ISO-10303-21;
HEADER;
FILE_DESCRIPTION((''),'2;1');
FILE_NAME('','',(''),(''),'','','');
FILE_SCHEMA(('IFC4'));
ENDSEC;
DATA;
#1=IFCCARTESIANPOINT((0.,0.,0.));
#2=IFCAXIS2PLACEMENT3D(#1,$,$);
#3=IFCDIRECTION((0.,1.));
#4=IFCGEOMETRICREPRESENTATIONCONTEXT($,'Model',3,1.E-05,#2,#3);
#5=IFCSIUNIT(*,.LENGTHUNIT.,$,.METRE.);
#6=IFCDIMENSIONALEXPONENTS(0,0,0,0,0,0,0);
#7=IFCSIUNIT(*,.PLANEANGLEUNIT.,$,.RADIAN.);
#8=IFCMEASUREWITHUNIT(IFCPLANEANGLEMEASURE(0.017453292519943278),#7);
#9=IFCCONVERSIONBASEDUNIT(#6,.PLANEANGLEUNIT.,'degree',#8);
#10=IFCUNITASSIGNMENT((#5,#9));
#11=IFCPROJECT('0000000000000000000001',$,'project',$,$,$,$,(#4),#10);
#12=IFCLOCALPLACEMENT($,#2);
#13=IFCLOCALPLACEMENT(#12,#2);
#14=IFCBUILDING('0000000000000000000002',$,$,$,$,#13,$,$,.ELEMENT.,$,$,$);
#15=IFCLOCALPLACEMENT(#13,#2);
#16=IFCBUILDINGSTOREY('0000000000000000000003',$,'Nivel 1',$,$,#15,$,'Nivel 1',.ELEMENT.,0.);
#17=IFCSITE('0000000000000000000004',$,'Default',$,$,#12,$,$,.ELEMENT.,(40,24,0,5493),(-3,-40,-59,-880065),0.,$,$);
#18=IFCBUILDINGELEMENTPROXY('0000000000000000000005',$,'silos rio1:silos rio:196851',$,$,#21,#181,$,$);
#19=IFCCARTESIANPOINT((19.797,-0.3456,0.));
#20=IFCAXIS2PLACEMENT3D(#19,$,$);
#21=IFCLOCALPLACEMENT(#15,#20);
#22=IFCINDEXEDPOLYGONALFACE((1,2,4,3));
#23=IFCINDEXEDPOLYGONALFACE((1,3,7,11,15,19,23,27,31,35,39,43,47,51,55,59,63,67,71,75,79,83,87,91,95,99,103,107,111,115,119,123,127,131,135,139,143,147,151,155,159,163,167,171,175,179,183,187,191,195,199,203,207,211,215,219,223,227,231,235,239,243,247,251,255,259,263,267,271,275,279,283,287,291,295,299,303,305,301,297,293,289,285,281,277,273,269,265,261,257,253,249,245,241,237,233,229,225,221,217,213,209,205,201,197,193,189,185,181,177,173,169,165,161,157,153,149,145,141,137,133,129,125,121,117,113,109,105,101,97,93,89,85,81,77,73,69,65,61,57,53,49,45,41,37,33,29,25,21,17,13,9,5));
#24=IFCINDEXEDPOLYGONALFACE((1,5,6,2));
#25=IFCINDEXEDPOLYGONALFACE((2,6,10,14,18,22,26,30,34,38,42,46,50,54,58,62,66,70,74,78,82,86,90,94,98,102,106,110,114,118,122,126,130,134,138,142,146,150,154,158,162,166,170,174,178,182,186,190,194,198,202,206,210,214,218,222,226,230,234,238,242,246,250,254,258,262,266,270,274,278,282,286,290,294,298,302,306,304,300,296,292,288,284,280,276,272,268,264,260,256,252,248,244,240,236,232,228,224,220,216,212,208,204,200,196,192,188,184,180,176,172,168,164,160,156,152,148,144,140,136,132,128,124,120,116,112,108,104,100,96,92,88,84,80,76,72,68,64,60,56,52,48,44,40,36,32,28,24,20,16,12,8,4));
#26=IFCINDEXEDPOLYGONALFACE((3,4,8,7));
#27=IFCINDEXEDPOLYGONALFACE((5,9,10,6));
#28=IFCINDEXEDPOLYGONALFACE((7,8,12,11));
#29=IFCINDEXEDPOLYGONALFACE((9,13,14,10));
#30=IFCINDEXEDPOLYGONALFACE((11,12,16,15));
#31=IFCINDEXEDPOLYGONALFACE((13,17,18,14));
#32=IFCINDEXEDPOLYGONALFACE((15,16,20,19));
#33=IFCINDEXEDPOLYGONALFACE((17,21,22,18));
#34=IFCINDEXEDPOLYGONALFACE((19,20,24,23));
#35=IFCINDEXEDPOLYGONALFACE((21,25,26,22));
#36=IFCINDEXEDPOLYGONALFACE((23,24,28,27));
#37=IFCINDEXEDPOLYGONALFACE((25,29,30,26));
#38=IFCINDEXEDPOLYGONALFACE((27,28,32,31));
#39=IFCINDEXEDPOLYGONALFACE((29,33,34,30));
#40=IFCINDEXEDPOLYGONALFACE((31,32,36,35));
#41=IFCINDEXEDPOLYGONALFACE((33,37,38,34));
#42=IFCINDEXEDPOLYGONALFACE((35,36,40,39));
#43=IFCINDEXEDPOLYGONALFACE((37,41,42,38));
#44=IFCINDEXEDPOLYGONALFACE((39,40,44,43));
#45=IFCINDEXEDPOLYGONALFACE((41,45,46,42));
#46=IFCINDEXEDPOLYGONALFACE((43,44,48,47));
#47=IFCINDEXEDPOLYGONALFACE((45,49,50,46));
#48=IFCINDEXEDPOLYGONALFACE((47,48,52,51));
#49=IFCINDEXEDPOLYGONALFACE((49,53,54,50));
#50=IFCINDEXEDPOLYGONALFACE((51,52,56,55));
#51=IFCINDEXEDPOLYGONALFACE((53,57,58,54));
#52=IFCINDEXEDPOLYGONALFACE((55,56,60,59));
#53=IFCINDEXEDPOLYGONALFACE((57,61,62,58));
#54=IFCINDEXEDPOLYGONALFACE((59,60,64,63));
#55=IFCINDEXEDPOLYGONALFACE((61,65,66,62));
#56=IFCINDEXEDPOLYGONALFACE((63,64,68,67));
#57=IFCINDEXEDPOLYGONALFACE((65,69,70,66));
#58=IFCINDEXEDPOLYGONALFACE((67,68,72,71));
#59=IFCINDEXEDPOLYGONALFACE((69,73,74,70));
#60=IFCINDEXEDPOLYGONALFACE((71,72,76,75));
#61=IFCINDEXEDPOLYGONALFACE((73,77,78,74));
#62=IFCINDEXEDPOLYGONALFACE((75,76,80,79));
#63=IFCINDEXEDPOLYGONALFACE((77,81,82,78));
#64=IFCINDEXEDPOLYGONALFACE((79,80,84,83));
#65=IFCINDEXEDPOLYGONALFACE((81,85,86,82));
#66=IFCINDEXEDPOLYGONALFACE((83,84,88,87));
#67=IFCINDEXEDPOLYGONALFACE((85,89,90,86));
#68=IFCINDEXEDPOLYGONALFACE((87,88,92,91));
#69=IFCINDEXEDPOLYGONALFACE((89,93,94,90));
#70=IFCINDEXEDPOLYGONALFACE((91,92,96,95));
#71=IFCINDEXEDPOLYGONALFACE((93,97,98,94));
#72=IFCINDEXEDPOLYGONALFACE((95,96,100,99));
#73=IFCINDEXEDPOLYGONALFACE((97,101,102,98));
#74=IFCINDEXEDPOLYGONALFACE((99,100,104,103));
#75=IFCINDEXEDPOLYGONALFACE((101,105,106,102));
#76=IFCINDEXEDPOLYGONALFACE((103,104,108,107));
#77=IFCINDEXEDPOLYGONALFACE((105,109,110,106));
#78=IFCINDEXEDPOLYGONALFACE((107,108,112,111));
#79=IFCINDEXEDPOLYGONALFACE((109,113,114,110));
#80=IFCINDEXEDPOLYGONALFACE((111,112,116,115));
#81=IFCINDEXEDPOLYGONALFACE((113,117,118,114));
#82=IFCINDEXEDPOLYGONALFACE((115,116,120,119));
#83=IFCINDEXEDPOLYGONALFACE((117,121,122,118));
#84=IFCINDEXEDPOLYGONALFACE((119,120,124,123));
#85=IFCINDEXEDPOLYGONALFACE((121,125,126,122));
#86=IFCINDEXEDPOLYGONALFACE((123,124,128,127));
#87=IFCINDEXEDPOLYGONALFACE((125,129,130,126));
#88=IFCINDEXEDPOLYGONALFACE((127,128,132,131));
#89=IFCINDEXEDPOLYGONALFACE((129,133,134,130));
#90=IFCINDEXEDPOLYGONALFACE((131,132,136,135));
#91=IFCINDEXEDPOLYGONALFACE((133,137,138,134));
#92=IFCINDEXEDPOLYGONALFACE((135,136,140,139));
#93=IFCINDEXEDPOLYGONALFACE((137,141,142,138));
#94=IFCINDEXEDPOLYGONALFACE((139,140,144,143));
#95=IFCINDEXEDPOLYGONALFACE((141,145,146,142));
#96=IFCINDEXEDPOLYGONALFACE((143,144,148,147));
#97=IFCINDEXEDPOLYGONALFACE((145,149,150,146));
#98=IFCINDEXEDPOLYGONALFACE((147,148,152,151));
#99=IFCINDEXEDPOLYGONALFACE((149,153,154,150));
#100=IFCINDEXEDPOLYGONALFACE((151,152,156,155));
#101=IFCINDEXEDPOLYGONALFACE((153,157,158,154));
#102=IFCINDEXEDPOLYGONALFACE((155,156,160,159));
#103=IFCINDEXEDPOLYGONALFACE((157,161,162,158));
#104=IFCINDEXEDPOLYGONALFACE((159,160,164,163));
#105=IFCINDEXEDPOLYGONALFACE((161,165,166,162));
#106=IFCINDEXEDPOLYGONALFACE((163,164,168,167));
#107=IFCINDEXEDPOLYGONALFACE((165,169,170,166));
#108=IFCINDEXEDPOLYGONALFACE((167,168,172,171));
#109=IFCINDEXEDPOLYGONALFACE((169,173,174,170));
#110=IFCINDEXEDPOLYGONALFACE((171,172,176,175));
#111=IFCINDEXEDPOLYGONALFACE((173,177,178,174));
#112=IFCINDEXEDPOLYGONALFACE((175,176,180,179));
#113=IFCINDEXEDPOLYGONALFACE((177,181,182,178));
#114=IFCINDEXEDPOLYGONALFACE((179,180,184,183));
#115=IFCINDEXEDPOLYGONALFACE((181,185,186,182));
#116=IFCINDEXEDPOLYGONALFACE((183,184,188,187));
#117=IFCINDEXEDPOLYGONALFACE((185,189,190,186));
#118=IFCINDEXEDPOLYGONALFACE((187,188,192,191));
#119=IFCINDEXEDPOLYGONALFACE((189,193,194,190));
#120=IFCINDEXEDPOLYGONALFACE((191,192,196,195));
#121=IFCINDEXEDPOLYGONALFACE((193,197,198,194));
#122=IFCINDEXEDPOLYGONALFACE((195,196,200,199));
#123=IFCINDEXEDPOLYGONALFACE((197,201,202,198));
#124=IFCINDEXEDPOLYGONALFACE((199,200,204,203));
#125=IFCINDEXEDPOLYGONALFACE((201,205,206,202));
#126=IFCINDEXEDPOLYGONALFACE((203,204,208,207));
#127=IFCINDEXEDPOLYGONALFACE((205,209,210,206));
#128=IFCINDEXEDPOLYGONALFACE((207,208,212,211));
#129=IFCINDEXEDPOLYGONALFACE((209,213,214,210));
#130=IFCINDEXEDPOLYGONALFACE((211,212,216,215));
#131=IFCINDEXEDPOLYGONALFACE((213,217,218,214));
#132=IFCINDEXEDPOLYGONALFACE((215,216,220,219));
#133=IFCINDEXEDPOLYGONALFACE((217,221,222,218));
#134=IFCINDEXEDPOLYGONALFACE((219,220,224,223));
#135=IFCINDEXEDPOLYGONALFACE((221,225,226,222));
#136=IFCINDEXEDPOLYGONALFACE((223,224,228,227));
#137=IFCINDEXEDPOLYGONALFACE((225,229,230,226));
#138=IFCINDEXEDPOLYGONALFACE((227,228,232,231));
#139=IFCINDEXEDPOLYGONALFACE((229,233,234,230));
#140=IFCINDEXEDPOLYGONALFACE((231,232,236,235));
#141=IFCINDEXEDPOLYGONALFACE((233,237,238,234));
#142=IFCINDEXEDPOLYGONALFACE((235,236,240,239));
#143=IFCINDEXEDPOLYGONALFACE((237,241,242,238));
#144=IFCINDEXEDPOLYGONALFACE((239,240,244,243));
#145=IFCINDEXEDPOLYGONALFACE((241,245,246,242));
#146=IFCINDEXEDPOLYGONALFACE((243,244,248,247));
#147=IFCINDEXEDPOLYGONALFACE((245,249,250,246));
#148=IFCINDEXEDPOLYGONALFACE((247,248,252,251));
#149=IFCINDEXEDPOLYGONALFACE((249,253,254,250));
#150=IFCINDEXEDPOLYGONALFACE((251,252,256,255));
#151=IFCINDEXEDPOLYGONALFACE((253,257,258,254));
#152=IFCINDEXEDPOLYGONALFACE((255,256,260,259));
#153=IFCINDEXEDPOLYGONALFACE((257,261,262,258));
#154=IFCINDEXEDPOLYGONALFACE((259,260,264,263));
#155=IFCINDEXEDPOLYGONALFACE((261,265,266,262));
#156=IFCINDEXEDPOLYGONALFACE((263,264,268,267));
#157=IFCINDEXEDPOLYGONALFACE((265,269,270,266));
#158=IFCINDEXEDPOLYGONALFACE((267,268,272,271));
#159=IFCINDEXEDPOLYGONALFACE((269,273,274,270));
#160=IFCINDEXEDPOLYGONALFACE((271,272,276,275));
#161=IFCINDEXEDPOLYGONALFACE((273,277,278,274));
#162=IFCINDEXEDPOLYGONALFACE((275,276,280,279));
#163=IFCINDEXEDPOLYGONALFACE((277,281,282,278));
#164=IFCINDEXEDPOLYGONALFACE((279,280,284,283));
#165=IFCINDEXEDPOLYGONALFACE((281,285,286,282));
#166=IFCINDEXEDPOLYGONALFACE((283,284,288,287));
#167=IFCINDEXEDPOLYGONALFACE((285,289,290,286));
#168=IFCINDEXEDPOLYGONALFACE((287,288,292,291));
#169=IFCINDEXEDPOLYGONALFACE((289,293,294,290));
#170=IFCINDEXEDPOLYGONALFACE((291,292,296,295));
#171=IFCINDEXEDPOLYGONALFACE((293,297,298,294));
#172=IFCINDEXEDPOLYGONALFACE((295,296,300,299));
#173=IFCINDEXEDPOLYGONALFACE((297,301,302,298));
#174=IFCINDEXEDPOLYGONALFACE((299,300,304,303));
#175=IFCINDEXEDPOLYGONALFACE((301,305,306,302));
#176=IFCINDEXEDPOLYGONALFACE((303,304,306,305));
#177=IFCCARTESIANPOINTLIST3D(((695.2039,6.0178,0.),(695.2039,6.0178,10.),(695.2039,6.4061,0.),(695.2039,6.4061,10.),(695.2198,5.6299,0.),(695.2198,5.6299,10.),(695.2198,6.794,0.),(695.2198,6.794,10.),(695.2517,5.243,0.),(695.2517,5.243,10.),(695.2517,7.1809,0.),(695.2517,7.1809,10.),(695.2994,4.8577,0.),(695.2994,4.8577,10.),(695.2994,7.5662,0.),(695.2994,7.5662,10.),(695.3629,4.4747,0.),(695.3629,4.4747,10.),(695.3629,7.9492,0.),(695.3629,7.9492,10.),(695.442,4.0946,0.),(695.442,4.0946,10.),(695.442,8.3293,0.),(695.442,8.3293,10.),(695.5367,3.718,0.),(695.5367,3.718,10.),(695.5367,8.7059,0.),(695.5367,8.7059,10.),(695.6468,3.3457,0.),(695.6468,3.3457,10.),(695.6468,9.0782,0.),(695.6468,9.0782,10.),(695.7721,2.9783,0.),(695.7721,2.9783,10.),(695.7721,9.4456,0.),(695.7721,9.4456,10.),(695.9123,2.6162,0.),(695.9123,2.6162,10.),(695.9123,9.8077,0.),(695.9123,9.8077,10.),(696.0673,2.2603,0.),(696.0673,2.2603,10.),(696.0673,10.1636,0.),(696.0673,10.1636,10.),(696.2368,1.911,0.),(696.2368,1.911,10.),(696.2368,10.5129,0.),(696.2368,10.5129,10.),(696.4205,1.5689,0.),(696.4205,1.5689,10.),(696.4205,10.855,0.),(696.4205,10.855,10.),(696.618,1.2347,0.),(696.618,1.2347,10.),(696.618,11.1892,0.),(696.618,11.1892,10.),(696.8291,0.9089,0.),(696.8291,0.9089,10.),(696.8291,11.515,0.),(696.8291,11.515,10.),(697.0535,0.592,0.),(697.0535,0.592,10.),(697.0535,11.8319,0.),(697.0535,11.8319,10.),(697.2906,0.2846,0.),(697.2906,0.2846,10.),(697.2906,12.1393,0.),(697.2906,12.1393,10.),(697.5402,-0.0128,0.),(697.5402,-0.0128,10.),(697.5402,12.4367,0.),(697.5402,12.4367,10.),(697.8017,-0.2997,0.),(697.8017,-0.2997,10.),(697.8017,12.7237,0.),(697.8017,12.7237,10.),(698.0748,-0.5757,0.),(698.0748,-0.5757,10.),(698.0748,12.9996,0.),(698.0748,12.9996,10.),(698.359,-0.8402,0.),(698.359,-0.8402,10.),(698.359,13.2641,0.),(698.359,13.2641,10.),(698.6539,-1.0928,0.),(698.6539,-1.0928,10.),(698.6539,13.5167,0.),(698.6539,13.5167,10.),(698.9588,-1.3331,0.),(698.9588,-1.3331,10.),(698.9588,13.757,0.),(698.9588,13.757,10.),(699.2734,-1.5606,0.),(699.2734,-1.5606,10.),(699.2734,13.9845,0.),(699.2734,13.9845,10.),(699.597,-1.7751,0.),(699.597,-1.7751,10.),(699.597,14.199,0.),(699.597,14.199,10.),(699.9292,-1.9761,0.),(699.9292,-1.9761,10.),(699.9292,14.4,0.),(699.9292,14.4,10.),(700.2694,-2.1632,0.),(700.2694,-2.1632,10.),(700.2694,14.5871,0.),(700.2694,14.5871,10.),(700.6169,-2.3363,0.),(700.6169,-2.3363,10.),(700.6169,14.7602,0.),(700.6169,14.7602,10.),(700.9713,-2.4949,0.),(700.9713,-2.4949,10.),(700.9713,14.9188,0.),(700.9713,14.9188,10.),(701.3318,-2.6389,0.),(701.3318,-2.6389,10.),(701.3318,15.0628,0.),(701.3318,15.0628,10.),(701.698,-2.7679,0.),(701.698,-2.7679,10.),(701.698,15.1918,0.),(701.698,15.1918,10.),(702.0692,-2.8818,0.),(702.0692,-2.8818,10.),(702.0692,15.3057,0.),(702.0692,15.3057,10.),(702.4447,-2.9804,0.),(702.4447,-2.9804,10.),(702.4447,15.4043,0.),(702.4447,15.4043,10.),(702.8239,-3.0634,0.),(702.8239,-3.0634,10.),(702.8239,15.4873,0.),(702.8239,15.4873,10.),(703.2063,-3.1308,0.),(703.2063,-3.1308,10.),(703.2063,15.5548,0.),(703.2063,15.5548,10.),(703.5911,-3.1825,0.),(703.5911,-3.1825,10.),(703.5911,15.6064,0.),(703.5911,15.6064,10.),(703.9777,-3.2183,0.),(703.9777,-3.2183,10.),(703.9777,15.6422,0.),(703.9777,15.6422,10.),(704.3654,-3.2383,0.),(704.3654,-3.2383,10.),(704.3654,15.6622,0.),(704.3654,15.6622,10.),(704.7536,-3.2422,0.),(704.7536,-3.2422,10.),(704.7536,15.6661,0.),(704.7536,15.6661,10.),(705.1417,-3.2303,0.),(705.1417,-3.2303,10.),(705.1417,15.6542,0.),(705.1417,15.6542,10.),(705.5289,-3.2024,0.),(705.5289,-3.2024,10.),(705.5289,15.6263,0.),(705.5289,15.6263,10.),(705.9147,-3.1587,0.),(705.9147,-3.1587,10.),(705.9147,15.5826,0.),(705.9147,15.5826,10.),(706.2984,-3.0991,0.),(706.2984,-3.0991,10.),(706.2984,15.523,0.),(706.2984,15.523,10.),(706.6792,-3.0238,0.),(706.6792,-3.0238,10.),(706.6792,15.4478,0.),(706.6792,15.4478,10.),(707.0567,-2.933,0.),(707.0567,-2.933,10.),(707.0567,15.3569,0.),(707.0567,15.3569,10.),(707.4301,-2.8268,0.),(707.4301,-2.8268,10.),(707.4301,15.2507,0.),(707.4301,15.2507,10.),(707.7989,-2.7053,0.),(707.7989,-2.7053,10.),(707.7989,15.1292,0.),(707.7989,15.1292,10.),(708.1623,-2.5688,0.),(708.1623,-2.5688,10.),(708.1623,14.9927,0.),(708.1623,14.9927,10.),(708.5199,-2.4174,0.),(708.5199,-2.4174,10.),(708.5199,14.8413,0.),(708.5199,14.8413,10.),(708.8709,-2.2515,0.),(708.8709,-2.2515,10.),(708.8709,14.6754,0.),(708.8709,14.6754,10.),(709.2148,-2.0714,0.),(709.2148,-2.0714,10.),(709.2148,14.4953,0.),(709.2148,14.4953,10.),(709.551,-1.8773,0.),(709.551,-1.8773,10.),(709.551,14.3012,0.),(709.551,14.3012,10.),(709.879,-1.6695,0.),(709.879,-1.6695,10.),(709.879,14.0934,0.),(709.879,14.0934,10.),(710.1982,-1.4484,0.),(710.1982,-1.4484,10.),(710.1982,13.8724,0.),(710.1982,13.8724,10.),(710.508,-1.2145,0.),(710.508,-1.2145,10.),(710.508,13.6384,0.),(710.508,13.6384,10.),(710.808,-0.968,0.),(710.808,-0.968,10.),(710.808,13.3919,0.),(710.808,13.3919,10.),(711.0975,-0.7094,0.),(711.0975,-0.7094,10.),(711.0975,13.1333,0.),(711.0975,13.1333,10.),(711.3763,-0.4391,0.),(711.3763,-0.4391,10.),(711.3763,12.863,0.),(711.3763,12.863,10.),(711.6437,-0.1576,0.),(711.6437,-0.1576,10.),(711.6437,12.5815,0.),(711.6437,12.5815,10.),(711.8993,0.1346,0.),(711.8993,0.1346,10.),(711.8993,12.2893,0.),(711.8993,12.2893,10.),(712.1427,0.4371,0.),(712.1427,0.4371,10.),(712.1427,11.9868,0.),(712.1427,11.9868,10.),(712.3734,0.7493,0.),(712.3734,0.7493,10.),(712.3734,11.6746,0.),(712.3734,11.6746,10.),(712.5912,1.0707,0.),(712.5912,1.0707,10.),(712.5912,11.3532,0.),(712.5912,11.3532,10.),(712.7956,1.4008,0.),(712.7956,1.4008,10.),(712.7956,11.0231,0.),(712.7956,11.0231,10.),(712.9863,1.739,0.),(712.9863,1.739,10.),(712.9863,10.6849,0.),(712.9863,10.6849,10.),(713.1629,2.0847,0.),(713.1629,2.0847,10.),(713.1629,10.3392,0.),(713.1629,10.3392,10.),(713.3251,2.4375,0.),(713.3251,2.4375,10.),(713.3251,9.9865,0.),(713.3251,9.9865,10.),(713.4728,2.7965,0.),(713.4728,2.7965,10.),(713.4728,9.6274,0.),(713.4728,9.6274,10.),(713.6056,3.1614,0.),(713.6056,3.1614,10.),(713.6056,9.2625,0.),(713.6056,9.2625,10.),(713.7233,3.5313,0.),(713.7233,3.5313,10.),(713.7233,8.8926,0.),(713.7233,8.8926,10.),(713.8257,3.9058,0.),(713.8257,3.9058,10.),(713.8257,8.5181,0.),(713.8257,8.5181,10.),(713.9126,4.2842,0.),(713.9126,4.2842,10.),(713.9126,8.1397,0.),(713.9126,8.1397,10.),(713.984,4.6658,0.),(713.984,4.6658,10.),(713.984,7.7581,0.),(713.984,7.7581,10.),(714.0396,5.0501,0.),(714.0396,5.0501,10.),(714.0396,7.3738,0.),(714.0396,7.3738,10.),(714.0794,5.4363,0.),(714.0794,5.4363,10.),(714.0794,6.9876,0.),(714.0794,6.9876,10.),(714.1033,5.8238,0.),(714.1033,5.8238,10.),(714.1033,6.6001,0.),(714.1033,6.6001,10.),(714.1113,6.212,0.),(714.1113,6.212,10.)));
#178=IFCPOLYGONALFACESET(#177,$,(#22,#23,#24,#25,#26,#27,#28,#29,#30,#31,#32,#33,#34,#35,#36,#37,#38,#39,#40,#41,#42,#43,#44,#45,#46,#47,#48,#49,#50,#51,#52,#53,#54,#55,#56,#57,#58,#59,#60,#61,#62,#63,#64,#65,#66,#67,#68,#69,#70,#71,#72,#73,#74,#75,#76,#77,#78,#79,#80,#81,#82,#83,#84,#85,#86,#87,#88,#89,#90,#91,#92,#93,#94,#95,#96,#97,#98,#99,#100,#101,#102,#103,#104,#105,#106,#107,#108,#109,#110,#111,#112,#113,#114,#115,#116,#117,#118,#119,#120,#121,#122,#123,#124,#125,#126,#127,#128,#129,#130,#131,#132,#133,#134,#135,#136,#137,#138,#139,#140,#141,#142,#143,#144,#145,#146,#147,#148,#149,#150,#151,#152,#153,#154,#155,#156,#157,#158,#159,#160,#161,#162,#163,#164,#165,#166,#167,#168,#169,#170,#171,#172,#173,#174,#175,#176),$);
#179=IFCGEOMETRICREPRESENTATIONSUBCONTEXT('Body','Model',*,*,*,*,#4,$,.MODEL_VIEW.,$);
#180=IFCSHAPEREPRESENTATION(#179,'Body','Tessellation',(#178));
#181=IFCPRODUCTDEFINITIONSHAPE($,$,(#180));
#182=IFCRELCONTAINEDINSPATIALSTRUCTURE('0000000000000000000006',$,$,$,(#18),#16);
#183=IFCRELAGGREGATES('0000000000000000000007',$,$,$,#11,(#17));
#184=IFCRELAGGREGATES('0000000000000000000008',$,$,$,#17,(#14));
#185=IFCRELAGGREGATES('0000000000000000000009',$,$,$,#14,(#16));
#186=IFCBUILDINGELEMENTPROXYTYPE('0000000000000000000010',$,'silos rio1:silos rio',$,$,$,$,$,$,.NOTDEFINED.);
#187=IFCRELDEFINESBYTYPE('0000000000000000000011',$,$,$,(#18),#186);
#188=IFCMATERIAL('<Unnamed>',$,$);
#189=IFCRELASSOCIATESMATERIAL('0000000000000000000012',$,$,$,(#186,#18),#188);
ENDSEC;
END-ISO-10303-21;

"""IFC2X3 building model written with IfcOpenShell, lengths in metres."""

from ifc_helpers import new_model, entity, si_unit, converted_unit, direction, frame, frame_2d, origin, place, context, subcontext, project, spatial, circle, extrude, source, transform, mapped, material, type_object, type_shapes, element, save


model = new_model("IFC2X3")

# Units and contexts
model_context = context("Model", 3, precision=1e-05, world=origin(), true_north=direction((0.0, 1.0)))
body_context = subcontext(model_context, "Body", "Model", "MODEL_VIEW")
ifc_project = project(units=[si_unit("LENGTHUNIT", "METRE"), converted_unit("PLANEANGLEUNIT", "degree", entity("IfcPlaneAngleMeasure", 0.017453292519943278), si_unit("PLANEANGLEUNIT", "RADIAN"), dimensions=[0, 0, 0, 0, 0, 0, 0])], contexts=[model_context])

# Site, building, storey
site_placement = place(None, origin())
site = spatial("IfcSite", under=ifc_project, at=site_placement, Name="Default", CompositionType="ELEMENT", RefLatitude=(40, 24, 0, 5493), RefLongitude=(-3, -40, -59, -880065), RefElevation=0.0)
building_placement = place(site_placement, origin())
building = spatial("IfcBuilding", under=site, at=building_placement, CompositionType="ELEMENT")
storey_placement = place(building_placement, origin())
storey = spatial("IfcBuildingStorey", under=building, at=storey_placement, Name="Nivel 1", LongName="Nivel 1", CompositionType="ELEMENT", Elevation=0.0)

# Building element proxy
ifc_material_1 = material(Name="<Unnamed>")
building_element_proxy_type_1 = type_object("IfcBuildingElementProxyType", Name="silos rio1:silos rio", PredefinedType="NOTDEFINED", material=ifc_material_1)
shared_shape_1 = source(origin(), body_context, "Body", "SweptSolid", [
    extrude(circle(Radius=9.4547, at=frame_2d((0.0, 0.0), x_axis=(1.0, 0.0))), frame((704.6566, 6.212, 0.0)), (0.0, 0.0, 1.0), 10.0),
])
type_shapes(building_element_proxy_type_1, [shared_shape_1])
proxy_1_placement = place(storey_placement, frame((19.797, -0.3456, 0.0)))
element("IfcBuildingElementProxy", 1, at=proxy_1_placement, inside=storey, type_object=building_element_proxy_type_1, material=ifc_material_1, Name="silos rio1:silos rio:196851", context=body_context, shape_type="MappedRepresentation", body=[
    mapped(shared_shape_1, transform((0.0, 0.0, 0.0), scale=1.0)),
])

save(model, "model.ifc")
